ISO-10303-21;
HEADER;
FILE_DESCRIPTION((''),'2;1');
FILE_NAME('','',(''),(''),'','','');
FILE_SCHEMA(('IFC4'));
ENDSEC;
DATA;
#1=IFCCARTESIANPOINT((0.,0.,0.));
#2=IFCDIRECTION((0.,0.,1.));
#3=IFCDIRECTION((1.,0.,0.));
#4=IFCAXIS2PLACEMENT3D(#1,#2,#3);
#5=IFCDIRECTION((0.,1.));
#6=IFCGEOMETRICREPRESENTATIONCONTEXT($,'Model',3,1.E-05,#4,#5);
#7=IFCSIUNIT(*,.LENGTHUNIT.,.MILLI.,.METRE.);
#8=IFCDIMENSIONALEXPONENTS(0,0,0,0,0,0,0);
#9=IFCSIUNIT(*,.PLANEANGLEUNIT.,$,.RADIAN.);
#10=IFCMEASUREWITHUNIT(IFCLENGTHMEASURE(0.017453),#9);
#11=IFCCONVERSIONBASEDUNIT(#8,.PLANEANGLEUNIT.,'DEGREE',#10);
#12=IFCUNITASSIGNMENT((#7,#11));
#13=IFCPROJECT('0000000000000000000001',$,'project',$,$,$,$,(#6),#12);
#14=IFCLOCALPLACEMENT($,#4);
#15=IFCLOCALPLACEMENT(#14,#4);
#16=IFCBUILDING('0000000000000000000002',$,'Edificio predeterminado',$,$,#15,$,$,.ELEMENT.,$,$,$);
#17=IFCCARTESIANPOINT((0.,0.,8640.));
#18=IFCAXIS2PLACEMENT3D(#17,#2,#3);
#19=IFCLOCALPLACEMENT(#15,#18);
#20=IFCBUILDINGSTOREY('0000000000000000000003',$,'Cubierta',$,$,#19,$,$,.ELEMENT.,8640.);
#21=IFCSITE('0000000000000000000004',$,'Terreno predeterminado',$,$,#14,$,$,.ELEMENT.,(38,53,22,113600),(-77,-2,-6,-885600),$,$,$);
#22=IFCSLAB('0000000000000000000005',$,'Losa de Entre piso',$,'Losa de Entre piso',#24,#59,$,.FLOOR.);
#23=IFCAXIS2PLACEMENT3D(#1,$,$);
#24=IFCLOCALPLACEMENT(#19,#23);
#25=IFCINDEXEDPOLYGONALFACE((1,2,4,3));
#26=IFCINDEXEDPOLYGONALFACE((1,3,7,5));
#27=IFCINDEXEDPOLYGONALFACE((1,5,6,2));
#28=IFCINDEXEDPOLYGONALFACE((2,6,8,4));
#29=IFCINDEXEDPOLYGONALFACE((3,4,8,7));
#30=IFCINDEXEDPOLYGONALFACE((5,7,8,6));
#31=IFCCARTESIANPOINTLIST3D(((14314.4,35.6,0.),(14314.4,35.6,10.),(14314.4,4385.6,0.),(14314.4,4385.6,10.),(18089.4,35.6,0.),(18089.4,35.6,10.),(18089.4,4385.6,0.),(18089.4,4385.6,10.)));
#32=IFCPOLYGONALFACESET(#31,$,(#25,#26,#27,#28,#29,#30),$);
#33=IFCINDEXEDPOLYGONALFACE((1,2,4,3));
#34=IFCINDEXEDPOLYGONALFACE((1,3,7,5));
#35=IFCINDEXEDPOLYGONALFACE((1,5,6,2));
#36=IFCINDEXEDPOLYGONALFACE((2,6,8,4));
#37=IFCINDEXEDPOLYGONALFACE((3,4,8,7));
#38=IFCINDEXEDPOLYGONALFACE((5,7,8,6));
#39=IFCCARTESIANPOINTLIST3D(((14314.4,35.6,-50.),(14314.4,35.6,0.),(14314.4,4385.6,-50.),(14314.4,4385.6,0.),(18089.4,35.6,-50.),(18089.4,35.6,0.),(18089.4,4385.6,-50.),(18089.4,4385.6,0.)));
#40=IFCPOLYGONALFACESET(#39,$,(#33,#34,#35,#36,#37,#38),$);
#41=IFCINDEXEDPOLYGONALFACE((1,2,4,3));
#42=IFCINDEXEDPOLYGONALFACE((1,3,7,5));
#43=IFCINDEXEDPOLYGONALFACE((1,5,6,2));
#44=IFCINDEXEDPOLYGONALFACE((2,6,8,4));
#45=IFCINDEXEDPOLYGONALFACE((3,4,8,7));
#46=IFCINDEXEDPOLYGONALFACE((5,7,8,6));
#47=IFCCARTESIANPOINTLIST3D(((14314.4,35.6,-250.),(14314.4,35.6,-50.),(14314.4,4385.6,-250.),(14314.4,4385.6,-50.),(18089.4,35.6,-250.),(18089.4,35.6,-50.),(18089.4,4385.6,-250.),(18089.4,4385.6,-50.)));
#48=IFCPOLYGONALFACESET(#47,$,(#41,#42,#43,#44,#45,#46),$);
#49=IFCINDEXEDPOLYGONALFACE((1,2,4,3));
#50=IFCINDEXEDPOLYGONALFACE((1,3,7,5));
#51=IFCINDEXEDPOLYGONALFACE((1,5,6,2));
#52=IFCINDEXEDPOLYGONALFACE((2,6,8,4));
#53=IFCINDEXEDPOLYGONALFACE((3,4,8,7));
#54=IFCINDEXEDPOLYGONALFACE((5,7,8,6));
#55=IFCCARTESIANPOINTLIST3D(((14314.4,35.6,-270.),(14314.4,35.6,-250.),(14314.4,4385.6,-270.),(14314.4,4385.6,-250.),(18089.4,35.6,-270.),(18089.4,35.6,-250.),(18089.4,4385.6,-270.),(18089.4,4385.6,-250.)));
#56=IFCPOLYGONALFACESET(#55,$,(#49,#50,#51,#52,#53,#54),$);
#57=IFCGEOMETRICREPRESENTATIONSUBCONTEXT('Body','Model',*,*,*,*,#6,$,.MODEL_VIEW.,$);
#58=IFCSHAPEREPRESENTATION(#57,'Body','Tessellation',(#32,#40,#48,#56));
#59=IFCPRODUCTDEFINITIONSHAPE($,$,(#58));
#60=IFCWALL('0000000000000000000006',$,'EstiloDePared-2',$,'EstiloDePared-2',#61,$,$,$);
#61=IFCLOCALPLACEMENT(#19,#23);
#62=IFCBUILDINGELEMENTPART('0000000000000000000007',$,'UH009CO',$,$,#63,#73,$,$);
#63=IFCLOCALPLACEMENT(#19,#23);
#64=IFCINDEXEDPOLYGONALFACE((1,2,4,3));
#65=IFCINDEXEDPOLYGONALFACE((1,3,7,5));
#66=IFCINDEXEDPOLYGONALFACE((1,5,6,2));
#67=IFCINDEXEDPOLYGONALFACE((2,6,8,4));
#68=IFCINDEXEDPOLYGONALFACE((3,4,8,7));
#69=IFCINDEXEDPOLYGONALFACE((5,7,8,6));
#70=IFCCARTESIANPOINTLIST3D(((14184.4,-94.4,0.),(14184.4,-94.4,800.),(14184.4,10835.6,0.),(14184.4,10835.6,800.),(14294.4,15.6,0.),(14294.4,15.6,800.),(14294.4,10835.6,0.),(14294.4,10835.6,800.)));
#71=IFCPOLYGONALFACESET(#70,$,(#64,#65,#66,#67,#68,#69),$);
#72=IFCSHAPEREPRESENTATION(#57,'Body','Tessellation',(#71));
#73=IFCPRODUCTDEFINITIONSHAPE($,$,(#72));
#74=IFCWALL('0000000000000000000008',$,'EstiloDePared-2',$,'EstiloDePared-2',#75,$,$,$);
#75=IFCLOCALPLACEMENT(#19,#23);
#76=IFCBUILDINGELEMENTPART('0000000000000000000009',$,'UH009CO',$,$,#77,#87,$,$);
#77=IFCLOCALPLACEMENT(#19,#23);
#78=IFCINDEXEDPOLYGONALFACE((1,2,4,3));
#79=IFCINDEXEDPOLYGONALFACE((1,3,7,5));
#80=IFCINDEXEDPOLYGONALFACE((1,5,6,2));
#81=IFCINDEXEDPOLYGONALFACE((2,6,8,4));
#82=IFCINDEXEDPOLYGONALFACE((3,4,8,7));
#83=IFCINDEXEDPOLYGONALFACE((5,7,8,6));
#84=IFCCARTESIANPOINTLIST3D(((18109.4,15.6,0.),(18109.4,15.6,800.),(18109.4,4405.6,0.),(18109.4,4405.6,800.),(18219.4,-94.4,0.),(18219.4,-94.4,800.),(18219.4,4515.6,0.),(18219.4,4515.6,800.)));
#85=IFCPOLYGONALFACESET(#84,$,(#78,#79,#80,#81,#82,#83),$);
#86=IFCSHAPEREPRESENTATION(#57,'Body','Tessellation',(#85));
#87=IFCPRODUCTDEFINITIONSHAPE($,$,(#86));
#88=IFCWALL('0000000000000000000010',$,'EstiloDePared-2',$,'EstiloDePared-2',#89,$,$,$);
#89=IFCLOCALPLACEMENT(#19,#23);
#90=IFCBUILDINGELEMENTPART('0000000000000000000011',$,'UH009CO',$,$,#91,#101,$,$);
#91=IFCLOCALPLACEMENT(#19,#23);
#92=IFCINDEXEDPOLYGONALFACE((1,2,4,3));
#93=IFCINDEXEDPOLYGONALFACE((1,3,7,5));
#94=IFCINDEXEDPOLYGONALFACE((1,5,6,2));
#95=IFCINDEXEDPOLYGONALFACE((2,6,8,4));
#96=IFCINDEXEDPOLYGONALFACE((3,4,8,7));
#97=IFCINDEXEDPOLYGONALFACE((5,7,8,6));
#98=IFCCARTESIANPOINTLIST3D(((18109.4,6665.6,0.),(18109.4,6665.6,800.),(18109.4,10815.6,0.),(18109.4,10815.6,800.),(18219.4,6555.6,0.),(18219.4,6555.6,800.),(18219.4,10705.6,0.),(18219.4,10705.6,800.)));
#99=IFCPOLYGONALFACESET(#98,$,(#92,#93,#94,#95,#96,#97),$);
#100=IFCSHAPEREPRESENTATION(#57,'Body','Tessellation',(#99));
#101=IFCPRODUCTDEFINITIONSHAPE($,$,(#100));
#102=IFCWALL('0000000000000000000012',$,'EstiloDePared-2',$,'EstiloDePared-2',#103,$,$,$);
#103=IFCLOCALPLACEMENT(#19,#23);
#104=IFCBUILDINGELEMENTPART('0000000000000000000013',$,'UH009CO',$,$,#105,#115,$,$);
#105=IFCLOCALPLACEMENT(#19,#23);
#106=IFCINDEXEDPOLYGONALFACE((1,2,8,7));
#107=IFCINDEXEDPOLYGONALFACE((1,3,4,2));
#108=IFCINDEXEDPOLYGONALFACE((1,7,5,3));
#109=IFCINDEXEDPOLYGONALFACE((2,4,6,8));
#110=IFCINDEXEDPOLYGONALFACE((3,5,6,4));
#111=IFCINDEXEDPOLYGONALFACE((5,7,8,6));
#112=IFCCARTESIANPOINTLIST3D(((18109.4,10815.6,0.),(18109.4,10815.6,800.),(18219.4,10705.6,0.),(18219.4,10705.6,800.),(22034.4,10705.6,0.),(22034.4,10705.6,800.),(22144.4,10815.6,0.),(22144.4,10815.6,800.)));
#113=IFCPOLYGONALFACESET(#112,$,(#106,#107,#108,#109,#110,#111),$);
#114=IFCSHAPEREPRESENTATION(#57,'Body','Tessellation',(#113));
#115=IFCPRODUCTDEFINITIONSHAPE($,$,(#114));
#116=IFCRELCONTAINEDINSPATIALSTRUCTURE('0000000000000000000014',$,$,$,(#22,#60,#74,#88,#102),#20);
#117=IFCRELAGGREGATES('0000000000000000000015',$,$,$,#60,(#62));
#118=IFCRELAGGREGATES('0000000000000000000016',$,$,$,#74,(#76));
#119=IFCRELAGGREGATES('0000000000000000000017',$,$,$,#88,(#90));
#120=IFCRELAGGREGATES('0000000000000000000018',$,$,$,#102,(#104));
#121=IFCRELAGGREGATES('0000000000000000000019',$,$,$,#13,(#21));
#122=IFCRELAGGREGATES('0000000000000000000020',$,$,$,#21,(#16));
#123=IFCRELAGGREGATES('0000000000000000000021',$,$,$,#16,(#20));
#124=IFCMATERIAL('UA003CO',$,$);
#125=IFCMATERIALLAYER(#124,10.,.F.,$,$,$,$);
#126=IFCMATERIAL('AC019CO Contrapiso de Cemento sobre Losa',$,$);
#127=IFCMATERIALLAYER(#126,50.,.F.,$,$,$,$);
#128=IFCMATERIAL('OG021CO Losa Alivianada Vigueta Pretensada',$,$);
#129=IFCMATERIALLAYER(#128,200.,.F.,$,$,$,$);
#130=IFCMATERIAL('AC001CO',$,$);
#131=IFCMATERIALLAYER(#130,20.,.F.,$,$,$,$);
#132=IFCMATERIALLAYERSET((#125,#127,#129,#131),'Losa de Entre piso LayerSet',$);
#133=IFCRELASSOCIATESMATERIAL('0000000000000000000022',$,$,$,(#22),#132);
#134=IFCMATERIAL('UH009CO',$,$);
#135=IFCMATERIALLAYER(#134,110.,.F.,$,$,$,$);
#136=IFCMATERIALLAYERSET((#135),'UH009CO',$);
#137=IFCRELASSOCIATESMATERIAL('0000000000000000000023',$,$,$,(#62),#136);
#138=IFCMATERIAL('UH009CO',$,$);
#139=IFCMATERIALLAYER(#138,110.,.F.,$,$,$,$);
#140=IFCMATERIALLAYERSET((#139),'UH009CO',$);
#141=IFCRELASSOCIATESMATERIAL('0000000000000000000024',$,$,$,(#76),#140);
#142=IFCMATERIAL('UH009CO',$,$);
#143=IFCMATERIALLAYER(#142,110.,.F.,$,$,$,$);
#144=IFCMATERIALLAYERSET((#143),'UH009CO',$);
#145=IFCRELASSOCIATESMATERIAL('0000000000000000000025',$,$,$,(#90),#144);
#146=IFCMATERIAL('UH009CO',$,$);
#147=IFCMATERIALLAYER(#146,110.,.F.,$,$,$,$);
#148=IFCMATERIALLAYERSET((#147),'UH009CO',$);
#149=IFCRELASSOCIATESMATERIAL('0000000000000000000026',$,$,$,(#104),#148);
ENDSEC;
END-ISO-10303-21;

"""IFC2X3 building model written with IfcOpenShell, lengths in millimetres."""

from ifc_helpers import new_model, entity, si_unit, converted_unit, direction, frame, origin_with_axes, place, context, subcontext, project, spatial, polyline, outline, extrude, material, layer, layer_set, layer_usage, element, aggregate, save


model = new_model("IFC2X3")

# Units and contexts
model_context = context("Model", 3, precision=1e-05, world=origin_with_axes(), true_north=direction((0.0, 1.0)))
body_context = subcontext(model_context, "Body", "Model", "MODEL_VIEW")
ifc_project = project(units=[si_unit("LENGTHUNIT", "METRE", prefix="MILLI"), converted_unit("PLANEANGLEUNIT", "DEGREE", entity("IfcLengthMeasure", 0.017453), si_unit("PLANEANGLEUNIT", "RADIAN"), dimensions=[0, 0, 0, 0, 0, 0, 0])], contexts=[model_context])

# Site, building, storey
site_placement = place(None, origin_with_axes())
site = spatial("IfcSite", under=ifc_project, at=site_placement, Name="Terreno predeterminado", CompositionType="ELEMENT", RefLatitude=(38, 53, 22, 113600), RefLongitude=(-77, -2, -6, -885600))
building_placement = place(site_placement, origin_with_axes())
building = spatial("IfcBuilding", under=site, at=building_placement, Name="Edificio predeterminado", CompositionType="ELEMENT")
storey_placement = place(building_placement, frame((0.0, 0.0, 8640.0), z_axis=(0.0, 0.0, 1.0), x_axis=(1.0, 0.0, 0.0)))
storey = spatial("IfcBuildingStorey", under=building, at=storey_placement, Name="Cubierta", CompositionType="ELEMENT", Elevation=8640.0)

# Slab
ifc_material_1 = material(Name="UA003CO")
ifc_layer_1 = layer(ifc_material_1, 10.0, ventilated=False)
ifc_material_2 = material(Name="AC019CO Contrapiso de Cemento sobre Losa")
ifc_layer_2 = layer(ifc_material_2, 50.0, ventilated=False)
ifc_material_3 = material(Name="OG021CO Losa Alivianada Vigueta Pretensada")
ifc_layer_3 = layer(ifc_material_3, 200.0, ventilated=False)
ifc_material_4 = material(Name="AC001CO")
ifc_layer_4 = layer(ifc_material_4, 20.0, ventilated=False)
ifc_layer_set_1 = layer_set([ifc_layer_1, ifc_layer_2, ifc_layer_3, ifc_layer_4], Name="Losa de Entre piso LayerSet")
ifc_layer_usage_1 = layer_usage(ifc_layer_set_1, "AXIS3", "NEGATIVE", 0.0)
slab_1_placement = place(storey_placement, frame((0.0, 0.0, -8640.0), z_axis=(0.0, 0.0, 1.0), x_axis=(1.0, 0.0, 0.0)))
element("IfcSlab", 1, at=slab_1_placement, inside=storey, material=ifc_layer_usage_1, Name="Losa de Entre piso", ObjectType="Losa de Entre piso", PredefinedType="FLOOR", context=body_context, shape_type="SweptSolid", body=[
    extrude(outline(polyline([(0.0, 4350.0), (3775.0, 4350.0), (3775.0, 0.0), (0.0, 0.0), (0.0, 4350.0)])), frame((18089.4, 35.6, 8640.0), z_axis=(0.0, 0.0, -1.0), x_axis=(-1.0, 0.0, 0.0)), (0.0, 0.0, -1.0), 10.0),
    extrude(outline(polyline([(0.0, 4350.0), (3775.0, 4350.0), (3775.0, 0.0), (0.0, 0.0), (0.0, 4350.0)])), frame((18089.4, 35.6, 8590.0), z_axis=(0.0, 0.0, -1.0), x_axis=(-1.0, 0.0, 0.0)), (0.0, 0.0, -1.0), 50.0),
    extrude(outline(polyline([(0.0, 4350.0), (3775.0, 4350.0), (3775.0, 0.0), (0.0, 0.0), (0.0, 4350.0)])), frame((18089.4, 35.6, 8390.0), z_axis=(0.0, 0.0, -1.0), x_axis=(-1.0, 0.0, 0.0)), (0.0, 0.0, -1.0), 200.0),
    extrude(outline(polyline([(0.0, 4350.0), (3775.0, 4350.0), (3775.0, 0.0), (0.0, 0.0), (0.0, 4350.0)])), frame((18089.4, 35.6, 8370.0), z_axis=(0.0, 0.0, -1.0), x_axis=(-1.0, 0.0, 0.0)), (0.0, 0.0, -1.0), 20.0),
])

# Walls, building element parts
wall_1_placement = place(storey_placement, frame((14239.4, -39.4, 0.0), z_axis=(0.0, 0.0, 1.0), x_axis=(0.0, 1.0, 0.0)))
wall_1 = element("IfcWall", 2, at=wall_1_placement, inside=storey, Name="EstiloDePared-2", ObjectType="EstiloDePared-2")
ifc_material_5 = material(Name="UH009CO")
ifc_layer_5 = layer(ifc_material_5, 110.0, ventilated=False)
ifc_layer_set_2 = layer_set([ifc_layer_5], Name="UH009CO")
ifc_layer_usage_2 = layer_usage(ifc_layer_set_2, "AXIS2", "NEGATIVE", -55.0)
building_element_part_1_placement = place(wall_1_placement, origin_with_axes())
building_element_part_1 = element("IfcBuildingElementPart", 3, at=building_element_part_1_placement, material=ifc_layer_usage_2, Name="UH009CO", context=body_context, shape_type="SweptSolid", body=[
    extrude(outline(polyline([(10875.0, 55.0), (10875.0, -55.0), (55.0, -55.0), (-55.0, 55.0), (10875.0, 55.0)])), origin_with_axes(), (0.0, 0.0, 1.0), 800.0),
])
aggregate(wall_1, [building_element_part_1])
wall_2_placement = place(storey_placement, frame((18164.4, -39.4, 0.0), z_axis=(0.0, 0.0, 1.0), x_axis=(0.0, 1.0, 0.0)))
wall_2 = element("IfcWall", 4, at=wall_2_placement, inside=storey, Name="EstiloDePared-2", ObjectType="EstiloDePared-2")
ifc_material_6 = material(Name="UH009CO")
ifc_layer_6 = layer(ifc_material_6, 110.0, ventilated=False)
ifc_layer_set_3 = layer_set([ifc_layer_6], Name="UH009CO")
ifc_layer_usage_3 = layer_usage(ifc_layer_set_3, "AXIS2", "NEGATIVE", -55.0)
building_element_part_2_placement = place(wall_2_placement, origin_with_axes())
building_element_part_2 = element("IfcBuildingElementPart", 5, at=building_element_part_2_placement, material=ifc_layer_usage_3, Name="UH009CO", context=body_context, shape_type="SweptSolid", body=[
    extrude(outline(polyline([(4445.0, 55.0), (4555.0, -55.0), (-55.0, -55.0), (55.0, 55.0), (4445.0, 55.0)])), origin_with_axes(), (0.0, 0.0, 1.0), 800.0),
])
aggregate(wall_2, [building_element_part_2])
wall_3_placement = place(storey_placement, frame((18164.4, 6610.6, 0.0), z_axis=(0.0, 0.0, 1.0), x_axis=(0.0, 1.0, 0.0)))
wall_3 = element("IfcWall", 6, at=wall_3_placement, inside=storey, Name="EstiloDePared-2", ObjectType="EstiloDePared-2")
ifc_material_7 = material(Name="UH009CO")
ifc_layer_7 = layer(ifc_material_7, 110.0, ventilated=False)
ifc_layer_set_4 = layer_set([ifc_layer_7], Name="UH009CO")
ifc_layer_usage_4 = layer_usage(ifc_layer_set_4, "AXIS2", "NEGATIVE", -55.0)
building_element_part_3_placement = place(wall_3_placement, origin_with_axes())
building_element_part_3 = element("IfcBuildingElementPart", 7, at=building_element_part_3_placement, material=ifc_layer_usage_4, Name="UH009CO", context=body_context, shape_type="SweptSolid", body=[
    extrude(outline(polyline([(4205.0, 55.0), (4095.0, -55.0), (-55.0, -55.0), (55.0, 55.0), (4205.0, 55.0)])), origin_with_axes(), (0.0, 0.0, 1.0), 800.0),
])
aggregate(wall_3, [building_element_part_3])
wall_4_placement = place(storey_placement, frame((18164.4, 10760.6, 0.0), z_axis=(0.0, 0.0, 1.0), x_axis=(1.0, 0.0, 0.0)))
wall_4 = element("IfcWall", 8, at=wall_4_placement, inside=storey, Name="EstiloDePared-2", ObjectType="EstiloDePared-2")
ifc_material_8 = material(Name="UH009CO")
ifc_layer_8 = layer(ifc_material_8, 110.0, ventilated=False)
ifc_layer_set_5 = layer_set([ifc_layer_8], Name="UH009CO")
ifc_layer_usage_5 = layer_usage(ifc_layer_set_5, "AXIS2", "NEGATIVE", -55.0)
building_element_part_4_placement = place(wall_4_placement, origin_with_axes())
building_element_part_4 = element("IfcBuildingElementPart", 9, at=building_element_part_4_placement, material=ifc_layer_usage_5, Name="UH009CO", context=body_context, shape_type="SweptSolid", body=[
    extrude(outline(polyline([(3980.0, 55.0), (3870.0, -55.0), (55.0, -55.0), (-55.0, 55.0), (3980.0, 55.0)])), origin_with_axes(), (0.0, 0.0, 1.0), 800.0),
])
aggregate(wall_4, [building_element_part_4])

save(model, "model.ifc")
